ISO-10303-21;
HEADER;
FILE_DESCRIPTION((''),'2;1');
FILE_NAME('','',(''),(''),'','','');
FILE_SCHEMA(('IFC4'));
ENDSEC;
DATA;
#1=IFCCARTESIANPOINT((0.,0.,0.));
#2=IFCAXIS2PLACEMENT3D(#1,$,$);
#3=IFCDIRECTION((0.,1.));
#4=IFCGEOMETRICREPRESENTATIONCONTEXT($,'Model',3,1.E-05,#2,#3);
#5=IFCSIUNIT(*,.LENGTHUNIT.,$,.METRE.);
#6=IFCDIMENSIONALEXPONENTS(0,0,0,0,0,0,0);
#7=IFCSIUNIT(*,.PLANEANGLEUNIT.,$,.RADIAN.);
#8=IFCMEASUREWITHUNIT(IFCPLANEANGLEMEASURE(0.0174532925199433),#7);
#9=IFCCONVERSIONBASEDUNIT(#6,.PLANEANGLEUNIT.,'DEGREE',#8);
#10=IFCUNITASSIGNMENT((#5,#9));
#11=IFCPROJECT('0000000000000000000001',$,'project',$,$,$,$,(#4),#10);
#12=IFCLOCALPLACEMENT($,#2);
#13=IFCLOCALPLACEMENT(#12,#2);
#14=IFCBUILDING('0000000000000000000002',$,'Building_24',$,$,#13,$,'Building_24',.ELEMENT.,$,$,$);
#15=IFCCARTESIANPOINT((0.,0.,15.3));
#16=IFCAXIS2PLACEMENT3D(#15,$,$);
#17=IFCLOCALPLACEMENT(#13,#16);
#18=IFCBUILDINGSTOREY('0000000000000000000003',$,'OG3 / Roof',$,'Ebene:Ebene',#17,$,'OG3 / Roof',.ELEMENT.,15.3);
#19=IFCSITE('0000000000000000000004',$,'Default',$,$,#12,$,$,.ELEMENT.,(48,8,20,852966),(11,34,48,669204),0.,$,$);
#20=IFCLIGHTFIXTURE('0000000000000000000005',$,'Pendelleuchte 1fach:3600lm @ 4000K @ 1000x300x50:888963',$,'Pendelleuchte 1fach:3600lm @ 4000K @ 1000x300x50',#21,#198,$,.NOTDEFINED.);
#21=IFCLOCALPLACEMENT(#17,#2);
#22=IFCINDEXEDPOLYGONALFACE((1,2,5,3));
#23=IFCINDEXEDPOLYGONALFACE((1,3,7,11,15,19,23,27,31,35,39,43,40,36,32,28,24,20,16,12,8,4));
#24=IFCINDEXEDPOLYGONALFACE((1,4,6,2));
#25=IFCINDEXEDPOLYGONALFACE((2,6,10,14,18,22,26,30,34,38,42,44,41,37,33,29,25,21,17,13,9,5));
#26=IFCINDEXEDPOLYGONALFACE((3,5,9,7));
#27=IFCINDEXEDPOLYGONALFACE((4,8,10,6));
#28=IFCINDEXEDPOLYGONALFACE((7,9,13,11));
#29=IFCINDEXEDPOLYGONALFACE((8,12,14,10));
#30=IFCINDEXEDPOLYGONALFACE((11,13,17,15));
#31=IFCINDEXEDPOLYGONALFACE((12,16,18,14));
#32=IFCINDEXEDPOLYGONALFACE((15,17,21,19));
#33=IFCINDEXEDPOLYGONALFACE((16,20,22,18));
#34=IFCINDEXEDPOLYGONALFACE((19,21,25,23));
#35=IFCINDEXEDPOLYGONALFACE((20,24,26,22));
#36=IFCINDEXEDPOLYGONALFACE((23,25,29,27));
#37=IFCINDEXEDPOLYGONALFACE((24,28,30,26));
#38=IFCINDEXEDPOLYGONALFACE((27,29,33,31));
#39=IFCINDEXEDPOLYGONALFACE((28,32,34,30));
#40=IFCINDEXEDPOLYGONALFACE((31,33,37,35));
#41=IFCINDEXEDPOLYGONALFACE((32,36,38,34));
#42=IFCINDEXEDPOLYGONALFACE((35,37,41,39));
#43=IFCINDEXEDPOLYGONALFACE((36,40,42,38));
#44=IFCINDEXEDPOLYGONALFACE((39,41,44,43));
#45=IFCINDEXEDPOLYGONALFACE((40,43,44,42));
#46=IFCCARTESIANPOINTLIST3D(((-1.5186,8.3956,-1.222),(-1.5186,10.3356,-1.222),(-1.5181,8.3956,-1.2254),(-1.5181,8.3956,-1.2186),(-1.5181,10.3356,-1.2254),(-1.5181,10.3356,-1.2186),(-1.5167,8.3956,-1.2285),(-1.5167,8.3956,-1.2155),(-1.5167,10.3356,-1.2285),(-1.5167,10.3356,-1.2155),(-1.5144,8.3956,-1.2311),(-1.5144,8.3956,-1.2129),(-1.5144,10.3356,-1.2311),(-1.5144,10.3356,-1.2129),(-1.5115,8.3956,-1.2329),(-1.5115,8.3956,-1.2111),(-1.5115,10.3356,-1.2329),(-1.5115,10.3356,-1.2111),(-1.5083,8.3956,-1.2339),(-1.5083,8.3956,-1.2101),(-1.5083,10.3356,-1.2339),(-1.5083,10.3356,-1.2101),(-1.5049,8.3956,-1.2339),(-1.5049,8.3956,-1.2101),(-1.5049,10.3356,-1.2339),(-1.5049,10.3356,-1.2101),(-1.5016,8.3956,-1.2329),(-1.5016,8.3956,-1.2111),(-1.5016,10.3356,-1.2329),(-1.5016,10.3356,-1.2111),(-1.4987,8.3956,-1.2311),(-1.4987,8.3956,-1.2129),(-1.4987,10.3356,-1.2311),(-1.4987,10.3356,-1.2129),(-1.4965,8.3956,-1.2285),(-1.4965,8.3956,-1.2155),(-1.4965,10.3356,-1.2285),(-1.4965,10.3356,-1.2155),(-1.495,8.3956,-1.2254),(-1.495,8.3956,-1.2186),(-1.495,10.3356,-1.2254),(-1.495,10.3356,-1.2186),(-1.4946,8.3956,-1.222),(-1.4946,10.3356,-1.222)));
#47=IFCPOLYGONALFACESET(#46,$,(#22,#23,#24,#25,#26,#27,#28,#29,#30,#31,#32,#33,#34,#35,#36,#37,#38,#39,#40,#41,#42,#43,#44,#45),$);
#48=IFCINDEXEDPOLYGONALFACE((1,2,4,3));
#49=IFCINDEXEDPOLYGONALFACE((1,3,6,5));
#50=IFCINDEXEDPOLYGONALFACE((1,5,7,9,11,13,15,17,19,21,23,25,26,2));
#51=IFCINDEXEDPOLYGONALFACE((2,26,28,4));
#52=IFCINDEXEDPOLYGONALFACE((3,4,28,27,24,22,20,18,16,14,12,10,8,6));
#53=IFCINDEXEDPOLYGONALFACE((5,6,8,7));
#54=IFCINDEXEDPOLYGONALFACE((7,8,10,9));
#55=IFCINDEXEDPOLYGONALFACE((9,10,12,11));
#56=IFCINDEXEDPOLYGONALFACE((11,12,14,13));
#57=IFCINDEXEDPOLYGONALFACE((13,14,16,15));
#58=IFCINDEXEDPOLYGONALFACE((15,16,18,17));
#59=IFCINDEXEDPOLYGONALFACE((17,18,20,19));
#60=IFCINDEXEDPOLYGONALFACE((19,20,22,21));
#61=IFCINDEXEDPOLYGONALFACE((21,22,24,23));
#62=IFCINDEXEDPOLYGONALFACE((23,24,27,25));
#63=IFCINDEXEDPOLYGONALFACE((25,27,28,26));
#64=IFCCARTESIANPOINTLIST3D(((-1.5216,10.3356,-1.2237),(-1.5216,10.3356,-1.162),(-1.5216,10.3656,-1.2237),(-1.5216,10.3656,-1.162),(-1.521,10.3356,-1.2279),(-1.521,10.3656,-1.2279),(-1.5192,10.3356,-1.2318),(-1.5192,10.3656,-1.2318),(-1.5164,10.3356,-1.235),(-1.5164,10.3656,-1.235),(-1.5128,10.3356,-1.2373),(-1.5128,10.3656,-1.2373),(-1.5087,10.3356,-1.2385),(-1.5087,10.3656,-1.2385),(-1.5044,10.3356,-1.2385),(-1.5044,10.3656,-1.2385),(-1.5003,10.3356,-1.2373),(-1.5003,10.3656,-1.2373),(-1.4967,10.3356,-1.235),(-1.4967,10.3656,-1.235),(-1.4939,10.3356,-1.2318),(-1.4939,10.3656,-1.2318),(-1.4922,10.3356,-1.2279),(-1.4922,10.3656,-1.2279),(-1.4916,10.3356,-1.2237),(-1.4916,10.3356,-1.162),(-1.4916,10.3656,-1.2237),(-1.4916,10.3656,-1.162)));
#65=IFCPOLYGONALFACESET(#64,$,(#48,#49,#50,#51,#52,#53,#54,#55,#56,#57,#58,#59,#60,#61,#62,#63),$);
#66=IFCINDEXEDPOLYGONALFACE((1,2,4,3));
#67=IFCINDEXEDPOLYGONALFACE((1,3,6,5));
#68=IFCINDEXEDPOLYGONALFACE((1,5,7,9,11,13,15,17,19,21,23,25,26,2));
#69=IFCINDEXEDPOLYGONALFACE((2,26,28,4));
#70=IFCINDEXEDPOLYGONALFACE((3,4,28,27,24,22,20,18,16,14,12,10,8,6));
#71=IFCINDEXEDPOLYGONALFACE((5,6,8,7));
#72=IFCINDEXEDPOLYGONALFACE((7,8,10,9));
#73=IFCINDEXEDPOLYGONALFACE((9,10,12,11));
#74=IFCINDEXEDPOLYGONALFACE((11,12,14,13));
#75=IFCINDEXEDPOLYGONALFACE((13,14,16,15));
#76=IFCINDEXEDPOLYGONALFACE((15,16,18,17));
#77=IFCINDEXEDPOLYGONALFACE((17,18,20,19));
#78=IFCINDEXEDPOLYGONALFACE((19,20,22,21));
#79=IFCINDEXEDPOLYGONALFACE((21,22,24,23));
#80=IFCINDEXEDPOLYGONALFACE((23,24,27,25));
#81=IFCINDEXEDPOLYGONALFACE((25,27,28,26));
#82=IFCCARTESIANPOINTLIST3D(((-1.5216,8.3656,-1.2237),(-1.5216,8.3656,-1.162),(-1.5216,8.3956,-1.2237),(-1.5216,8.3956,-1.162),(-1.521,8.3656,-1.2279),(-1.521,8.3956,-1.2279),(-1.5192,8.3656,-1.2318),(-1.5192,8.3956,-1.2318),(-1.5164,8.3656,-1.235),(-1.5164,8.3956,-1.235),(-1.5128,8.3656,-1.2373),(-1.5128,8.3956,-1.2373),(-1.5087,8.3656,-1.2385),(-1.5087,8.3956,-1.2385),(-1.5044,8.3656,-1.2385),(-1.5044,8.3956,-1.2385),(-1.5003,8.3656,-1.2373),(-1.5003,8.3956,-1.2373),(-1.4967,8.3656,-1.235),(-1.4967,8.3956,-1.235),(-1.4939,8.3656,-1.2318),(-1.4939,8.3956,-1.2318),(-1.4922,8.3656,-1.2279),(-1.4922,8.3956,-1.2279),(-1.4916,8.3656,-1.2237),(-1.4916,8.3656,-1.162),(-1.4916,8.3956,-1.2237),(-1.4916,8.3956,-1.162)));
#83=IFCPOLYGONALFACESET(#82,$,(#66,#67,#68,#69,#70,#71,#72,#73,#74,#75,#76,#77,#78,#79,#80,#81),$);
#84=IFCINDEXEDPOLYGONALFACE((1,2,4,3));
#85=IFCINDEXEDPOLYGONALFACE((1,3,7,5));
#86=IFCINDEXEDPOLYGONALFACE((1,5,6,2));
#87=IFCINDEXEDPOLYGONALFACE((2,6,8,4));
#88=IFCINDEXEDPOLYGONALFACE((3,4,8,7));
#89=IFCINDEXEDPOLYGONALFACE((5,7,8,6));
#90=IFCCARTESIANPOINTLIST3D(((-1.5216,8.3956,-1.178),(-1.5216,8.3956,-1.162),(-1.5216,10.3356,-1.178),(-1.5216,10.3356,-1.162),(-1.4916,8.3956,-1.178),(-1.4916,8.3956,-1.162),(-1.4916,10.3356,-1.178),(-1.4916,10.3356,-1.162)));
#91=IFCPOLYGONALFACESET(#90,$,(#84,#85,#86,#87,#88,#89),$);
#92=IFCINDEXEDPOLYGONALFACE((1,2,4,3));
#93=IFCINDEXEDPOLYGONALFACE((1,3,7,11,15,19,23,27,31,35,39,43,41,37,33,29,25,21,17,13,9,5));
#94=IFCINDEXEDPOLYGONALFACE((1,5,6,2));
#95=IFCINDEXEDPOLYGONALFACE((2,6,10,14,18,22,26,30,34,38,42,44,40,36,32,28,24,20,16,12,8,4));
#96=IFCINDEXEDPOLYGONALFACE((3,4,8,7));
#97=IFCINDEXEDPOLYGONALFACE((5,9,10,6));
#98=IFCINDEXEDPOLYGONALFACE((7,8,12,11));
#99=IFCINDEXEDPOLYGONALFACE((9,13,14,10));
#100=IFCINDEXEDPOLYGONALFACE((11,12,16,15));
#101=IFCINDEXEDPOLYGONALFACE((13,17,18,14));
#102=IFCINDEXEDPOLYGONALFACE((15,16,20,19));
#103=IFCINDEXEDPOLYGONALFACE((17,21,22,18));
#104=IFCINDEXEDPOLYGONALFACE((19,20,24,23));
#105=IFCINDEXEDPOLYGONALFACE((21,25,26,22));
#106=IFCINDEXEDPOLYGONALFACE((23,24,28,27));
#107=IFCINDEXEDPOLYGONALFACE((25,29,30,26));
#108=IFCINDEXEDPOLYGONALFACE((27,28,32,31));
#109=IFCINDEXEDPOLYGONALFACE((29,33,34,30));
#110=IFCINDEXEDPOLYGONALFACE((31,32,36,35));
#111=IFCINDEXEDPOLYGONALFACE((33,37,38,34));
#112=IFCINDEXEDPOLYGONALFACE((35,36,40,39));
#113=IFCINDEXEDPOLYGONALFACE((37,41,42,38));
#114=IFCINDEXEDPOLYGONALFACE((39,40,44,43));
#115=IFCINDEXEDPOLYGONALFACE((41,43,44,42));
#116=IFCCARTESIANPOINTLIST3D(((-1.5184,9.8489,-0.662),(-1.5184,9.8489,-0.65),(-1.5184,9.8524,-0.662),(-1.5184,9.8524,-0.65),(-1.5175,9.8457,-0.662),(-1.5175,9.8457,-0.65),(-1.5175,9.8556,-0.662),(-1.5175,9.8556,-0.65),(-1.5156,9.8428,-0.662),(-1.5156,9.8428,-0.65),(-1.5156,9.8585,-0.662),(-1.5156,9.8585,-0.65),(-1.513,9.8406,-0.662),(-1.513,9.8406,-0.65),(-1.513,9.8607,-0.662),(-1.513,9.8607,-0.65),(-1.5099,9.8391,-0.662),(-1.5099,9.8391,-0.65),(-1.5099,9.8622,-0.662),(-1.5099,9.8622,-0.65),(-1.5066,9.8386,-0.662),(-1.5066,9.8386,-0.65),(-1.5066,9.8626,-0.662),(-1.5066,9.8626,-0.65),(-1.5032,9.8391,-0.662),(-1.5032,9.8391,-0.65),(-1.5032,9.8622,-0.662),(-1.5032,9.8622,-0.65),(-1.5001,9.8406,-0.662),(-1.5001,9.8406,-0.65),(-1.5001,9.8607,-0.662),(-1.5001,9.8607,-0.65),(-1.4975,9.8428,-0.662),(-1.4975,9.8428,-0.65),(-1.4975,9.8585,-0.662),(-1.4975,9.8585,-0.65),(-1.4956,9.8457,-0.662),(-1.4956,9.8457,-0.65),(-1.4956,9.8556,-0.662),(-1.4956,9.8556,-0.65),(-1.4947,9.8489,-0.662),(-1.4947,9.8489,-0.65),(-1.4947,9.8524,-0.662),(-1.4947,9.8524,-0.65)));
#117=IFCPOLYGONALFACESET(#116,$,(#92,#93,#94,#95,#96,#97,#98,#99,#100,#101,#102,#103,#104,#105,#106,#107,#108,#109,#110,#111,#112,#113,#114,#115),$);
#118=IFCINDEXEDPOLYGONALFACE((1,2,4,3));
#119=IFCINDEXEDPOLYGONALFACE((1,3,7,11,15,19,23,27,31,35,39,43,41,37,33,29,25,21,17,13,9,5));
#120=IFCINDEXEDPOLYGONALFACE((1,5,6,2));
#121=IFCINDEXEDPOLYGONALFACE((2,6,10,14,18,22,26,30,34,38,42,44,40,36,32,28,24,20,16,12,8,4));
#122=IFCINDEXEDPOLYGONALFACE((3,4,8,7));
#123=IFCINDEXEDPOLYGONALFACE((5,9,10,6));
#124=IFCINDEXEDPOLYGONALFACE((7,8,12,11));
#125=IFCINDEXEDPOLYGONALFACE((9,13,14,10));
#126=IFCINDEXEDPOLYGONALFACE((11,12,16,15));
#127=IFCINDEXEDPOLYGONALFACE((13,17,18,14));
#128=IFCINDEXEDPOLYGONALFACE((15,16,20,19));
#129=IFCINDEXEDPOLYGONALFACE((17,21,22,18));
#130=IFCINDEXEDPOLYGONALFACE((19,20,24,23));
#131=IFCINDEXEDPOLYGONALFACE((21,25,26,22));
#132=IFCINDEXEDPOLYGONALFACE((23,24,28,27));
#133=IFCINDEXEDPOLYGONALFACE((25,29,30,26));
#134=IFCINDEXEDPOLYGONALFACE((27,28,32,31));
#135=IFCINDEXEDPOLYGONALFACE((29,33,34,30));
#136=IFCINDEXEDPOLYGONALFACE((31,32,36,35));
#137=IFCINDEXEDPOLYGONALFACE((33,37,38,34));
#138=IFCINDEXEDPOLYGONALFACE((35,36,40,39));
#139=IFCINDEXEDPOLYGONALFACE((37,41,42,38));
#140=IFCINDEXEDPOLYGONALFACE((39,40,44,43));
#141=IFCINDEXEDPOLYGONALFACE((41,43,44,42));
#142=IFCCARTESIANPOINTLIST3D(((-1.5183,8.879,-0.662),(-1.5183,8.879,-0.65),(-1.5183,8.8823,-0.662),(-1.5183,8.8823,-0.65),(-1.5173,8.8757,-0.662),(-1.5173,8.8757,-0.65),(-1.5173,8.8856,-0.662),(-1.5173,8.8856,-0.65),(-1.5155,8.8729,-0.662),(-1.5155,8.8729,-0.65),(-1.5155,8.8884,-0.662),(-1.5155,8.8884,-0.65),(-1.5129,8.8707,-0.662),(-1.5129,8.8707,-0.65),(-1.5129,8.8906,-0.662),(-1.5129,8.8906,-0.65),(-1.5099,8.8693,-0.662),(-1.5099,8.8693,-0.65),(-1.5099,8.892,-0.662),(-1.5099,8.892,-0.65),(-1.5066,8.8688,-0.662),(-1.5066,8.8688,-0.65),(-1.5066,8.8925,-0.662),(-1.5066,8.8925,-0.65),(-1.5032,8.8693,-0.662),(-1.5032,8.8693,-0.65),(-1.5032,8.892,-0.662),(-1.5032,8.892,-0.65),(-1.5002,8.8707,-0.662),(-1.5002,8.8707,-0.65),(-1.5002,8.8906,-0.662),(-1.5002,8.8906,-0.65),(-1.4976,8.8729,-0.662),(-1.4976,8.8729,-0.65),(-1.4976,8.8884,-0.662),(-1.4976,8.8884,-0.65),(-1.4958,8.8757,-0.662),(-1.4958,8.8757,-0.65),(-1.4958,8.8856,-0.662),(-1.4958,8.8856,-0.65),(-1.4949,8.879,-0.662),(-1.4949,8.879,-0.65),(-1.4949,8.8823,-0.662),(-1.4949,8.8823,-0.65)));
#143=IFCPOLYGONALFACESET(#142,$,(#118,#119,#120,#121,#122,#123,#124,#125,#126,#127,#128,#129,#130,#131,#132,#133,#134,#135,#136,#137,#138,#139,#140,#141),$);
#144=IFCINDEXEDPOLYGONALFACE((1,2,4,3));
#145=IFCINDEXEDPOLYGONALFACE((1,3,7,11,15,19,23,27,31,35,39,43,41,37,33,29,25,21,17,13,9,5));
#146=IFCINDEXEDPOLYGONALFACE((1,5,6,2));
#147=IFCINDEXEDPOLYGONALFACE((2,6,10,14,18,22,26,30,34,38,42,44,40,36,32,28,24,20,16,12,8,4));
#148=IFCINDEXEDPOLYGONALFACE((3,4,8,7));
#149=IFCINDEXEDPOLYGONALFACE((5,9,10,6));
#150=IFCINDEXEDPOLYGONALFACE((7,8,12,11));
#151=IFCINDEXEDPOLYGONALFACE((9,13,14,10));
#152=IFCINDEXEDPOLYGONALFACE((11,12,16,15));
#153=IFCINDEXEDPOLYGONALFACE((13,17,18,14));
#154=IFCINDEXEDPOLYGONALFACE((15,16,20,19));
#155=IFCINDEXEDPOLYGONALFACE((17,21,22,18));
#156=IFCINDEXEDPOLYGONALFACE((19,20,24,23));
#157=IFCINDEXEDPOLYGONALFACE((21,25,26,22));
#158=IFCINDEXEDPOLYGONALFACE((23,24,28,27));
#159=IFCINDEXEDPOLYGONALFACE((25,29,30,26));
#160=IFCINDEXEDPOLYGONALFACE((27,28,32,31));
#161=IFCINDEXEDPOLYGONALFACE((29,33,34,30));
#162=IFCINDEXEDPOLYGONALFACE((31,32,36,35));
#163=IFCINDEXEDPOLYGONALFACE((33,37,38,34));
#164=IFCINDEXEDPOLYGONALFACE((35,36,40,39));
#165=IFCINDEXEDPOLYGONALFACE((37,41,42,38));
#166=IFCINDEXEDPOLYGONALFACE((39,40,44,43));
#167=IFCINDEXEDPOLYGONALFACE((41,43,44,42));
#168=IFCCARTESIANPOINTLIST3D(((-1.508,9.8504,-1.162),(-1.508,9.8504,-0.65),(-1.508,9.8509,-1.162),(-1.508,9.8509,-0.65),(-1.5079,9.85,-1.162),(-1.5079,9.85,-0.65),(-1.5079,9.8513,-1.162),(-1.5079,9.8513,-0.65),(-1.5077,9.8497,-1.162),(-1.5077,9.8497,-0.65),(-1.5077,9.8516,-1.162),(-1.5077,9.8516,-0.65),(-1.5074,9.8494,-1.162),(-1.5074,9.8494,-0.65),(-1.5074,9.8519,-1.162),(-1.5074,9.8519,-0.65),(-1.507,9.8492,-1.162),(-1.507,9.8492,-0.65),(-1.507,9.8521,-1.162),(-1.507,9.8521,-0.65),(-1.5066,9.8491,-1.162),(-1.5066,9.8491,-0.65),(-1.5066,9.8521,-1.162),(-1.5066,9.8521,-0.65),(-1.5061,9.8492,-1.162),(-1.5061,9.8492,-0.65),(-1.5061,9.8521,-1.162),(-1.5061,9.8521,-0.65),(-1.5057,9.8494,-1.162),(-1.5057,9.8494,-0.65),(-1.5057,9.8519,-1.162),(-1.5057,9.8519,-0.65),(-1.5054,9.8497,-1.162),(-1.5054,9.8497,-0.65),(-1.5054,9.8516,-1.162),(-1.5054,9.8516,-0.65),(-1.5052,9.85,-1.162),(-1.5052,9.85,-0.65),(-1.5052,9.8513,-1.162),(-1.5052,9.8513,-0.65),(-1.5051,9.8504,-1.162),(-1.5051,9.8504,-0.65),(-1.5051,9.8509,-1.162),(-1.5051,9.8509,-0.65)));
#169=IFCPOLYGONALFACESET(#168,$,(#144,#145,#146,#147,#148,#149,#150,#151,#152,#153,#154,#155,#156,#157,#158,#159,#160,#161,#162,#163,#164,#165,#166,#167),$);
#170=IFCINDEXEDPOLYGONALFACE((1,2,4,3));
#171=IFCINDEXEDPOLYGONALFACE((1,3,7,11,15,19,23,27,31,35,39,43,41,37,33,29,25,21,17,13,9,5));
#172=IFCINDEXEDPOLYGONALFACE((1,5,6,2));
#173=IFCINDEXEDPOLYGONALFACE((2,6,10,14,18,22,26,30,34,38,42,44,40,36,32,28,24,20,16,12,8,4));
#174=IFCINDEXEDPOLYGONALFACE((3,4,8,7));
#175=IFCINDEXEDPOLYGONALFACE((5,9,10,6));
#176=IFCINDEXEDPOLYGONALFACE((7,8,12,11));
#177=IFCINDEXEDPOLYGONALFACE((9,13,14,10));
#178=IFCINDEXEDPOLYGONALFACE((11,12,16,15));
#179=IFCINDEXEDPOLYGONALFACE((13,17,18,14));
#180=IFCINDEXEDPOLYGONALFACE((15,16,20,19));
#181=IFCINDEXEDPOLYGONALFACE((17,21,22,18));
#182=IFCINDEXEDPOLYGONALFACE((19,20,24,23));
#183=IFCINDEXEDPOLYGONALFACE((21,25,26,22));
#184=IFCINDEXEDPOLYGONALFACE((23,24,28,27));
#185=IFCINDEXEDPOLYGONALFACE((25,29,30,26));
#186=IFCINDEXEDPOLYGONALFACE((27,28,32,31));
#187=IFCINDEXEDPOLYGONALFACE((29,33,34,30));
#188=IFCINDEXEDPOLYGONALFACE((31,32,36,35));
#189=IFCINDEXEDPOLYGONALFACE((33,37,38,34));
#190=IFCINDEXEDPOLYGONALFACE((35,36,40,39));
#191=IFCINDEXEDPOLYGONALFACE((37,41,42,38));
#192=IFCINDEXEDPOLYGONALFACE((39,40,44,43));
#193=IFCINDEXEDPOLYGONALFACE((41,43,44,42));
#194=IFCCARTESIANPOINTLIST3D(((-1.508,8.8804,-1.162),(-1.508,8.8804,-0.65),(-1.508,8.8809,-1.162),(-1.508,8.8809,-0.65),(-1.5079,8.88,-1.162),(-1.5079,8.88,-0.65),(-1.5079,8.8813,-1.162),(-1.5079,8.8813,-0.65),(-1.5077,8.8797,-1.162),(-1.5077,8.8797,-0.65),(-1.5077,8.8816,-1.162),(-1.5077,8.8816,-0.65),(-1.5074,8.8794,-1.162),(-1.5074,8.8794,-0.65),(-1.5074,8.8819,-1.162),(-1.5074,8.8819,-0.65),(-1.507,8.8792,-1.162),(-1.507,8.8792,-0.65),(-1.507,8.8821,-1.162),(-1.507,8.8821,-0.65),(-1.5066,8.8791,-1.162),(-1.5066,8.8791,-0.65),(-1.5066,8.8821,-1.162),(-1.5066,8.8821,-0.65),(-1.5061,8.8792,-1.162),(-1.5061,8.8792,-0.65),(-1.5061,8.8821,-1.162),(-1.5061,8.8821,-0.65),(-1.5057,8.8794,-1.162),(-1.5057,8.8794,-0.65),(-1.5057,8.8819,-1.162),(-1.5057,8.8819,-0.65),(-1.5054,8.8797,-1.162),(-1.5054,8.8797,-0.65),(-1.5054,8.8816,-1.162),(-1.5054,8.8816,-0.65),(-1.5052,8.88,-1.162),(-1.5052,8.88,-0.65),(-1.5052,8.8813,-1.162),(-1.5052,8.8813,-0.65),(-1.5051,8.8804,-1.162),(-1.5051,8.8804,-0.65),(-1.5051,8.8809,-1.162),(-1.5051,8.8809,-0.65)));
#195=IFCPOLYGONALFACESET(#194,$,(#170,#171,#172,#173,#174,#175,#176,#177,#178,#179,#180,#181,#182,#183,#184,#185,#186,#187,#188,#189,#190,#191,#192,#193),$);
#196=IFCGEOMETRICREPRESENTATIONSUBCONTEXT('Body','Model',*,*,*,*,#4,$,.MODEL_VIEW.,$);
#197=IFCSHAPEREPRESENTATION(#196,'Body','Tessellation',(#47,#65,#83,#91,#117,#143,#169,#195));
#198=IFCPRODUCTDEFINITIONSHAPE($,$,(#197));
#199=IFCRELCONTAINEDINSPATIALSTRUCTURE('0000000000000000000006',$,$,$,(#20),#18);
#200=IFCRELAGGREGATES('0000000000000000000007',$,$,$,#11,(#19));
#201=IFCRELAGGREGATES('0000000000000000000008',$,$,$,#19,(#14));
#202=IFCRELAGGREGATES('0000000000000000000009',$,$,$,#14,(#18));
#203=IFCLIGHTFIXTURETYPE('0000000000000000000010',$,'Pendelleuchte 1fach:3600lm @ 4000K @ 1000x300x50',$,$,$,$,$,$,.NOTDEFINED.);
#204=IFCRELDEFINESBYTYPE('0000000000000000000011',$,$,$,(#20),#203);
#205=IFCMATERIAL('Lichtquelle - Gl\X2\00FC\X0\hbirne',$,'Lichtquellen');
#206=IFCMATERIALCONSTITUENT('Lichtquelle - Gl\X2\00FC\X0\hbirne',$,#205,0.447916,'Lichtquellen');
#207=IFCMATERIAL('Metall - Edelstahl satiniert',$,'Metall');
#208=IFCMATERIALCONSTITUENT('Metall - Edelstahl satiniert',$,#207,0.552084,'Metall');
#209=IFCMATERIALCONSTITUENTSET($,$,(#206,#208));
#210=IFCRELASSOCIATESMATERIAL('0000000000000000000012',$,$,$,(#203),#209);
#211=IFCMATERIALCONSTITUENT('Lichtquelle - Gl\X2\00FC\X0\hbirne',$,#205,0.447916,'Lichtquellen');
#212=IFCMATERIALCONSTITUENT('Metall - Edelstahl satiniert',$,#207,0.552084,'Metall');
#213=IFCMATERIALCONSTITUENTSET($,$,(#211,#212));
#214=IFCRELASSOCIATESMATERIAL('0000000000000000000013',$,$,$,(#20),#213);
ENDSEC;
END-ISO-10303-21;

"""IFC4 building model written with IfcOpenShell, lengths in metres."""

from ifc_helpers import new_model, entity, si_unit, converted_unit, direction, frame, origin, place, context, subcontext, project, spatial, line, arc, indexed_curve, outline, extrude, source, transform, mapped, material, constituent, constituent_set, type_object, type_shapes, element, save


model = new_model("IFC4")

# Units and contexts
model_context = context("Model", 3, precision=1e-05, world=origin(), true_north=direction((0.0, 1.0)))
body_context = subcontext(model_context, "Body", "Model", "MODEL_VIEW")
ifc_project = project(units=[si_unit("LENGTHUNIT", "METRE"), converted_unit("PLANEANGLEUNIT", "DEGREE", entity("IfcPlaneAngleMeasure", 0.0174532925199433), si_unit("PLANEANGLEUNIT", "RADIAN"), dimensions=[0, 0, 0, 0, 0, 0, 0])], contexts=[model_context])

# Site, building, storey
site_placement = place(None, origin())
site = spatial("IfcSite", under=ifc_project, at=site_placement, Name="Default", CompositionType="ELEMENT", RefLatitude=(48, 8, 20, 852966), RefLongitude=(11, 34, 48, 669204), RefElevation=0.0)
building_placement = place(site_placement, origin())
building = spatial("IfcBuilding", under=site, at=building_placement, Name="Building_24", LongName="Building_24", CompositionType="ELEMENT")
storey_placement = place(building_placement, frame((0.0, 0.0, 15.3)))
storey = spatial("IfcBuildingStorey", under=building, at=storey_placement, Name="OG3 / Roof", ObjectType="Ebene:Ebene", LongName="OG3 / Roof", CompositionType="ELEMENT", Elevation=15.3)

# Light fixture
ifc_material_1 = material(Name="Lichtquelle - Glühbirne", Category="Lichtquellen")
ifc_material_2 = material(Name="Metall - Edelstahl satiniert", Category="Metall")
ifc_constituent_1 = constituent(ifc_material_1, Name="Lichtquelle - Glühbirne", Category="Lichtquellen", fraction=0.447916)
ifc_constituent_2 = constituent(ifc_material_2, Name="Metall - Edelstahl satiniert", Category="Metall", fraction=0.552084)
ifc_constituent_set_1 = constituent_set(constituents=[ifc_constituent_1, ifc_constituent_2])
light_fixture_type_1 = type_object("IfcLightFixtureType", Name="Pendelleuchte 1fach:3600lm @ 4000K @ 1000x300x50", PredefinedType="NOTDEFINED", material=ifc_constituent_set_1)
shared_shape_1 = source(origin(), body_context, "Body", "SweptSolid", [
    extrude(outline(indexed_curve([(-0.012, 0.0), (0.0, -0.012), (0.012, 0.0), (0.0, 0.012)], segments=[arc(1, 2, 3), arc(3, 4, 1)], self_intersect=False)), frame((-0.97, 0.0, -0.572), z_axis=(1.0, 0.0, 0.0), x_axis=(0.0, 1.0, 0.0)), (0.0, 0.0, 1.0), 1.94),
    extrude(outline(indexed_curve([(-0.0308, -0.015), (0.0308, -0.015), (0.0308, 0.015), (-0.0308, 0.015), (-0.0458, 0.0)], segments=[line(1, 2, 3, 4), arc(4, 5, 1)], self_intersect=False)), frame((0.97, 0.0, -0.5428), z_axis=(1.0, 0.0, 0.0), x_axis=(0.0, 0.0, 1.0)), (0.0, 0.0, 1.0), 0.03),
    extrude(outline(indexed_curve([(-0.0308, -0.015), (0.0308, -0.015), (0.0308, 0.015), (-0.0308, 0.015), (-0.0458, 0.0)], segments=[line(1, 2, 3, 4), arc(4, 5, 1)], self_intersect=False)), frame((-1.0, 0.0, -0.5428), z_axis=(1.0, 0.0, 0.0), x_axis=(0.0, 0.0, 1.0)), (0.0, 0.0, 1.0), 0.03),
    extrude(outline(indexed_curve([(-0.97, -0.015), (0.97, -0.015), (0.97, 0.015), (-0.97, 0.015), (-0.97, -0.015)], self_intersect=False)), frame((0.0, 0.0, -0.528), z_axis=(0.0, 0.0, 1.0), x_axis=(-1.0, 0.0, 0.0)), (0.0, 0.0, 1.0), 0.016),
    extrude(outline(indexed_curve([(-0.012, 0.0), (0.0, -0.012), (0.012, 0.0), (0.0, 0.012)], segments=[arc(1, 2, 3), arc(3, 4, 1)], self_intersect=False)), frame((0.485, 0.0, -0.012)), (0.0, 0.0, 1.0), 0.012),
    extrude(outline(indexed_curve([(-0.0118, 0.0), (0.0, -0.0118), (0.0118, 0.0), (0.0, 0.0118)], segments=[arc(1, 2, 3), arc(3, 4, 1)], self_intersect=False)), frame((-0.485, 0.0, -0.012)), (0.0, 0.0, 1.0), 0.012),
    extrude(outline(indexed_curve([(-0.0015, 0.0), (0.0, -0.0015), (0.0015, 0.0), (0.0, 0.0015)], segments=[arc(1, 2, 3), arc(3, 4, 1)], self_intersect=False)), frame((0.485, 0.0, -0.512)), (0.0, 0.0, 1.0), 0.512),
    extrude(outline(indexed_curve([(-0.0015, 0.0), (0.0, -0.0015), (0.0015, 0.0), (0.0, 0.0015)], segments=[arc(1, 2, 3), arc(3, 4, 1)], self_intersect=False)), frame((-0.485, 0.0, -0.512)), (0.0, 0.0, 1.0), 0.512),
])
type_shapes(light_fixture_type_1, [shared_shape_1])
ifc_constituent_3 = constituent(ifc_material_1, Name="Lichtquelle - Glühbirne", Category="Lichtquellen", fraction=0.447916)
ifc_constituent_4 = constituent(ifc_material_2, Name="Metall - Edelstahl satiniert", Category="Metall", fraction=0.552084)
ifc_constituent_set_2 = constituent_set(constituents=[ifc_constituent_3, ifc_constituent_4])
light_fixture_1_placement = place(storey_placement, frame((-1.5066, 9.3656, -0.65), z_axis=(0.0, 0.0, 1.0), x_axis=(0.0, 1.0, 0.0)))
element("IfcLightFixture", 1, at=light_fixture_1_placement, inside=storey, type_object=light_fixture_type_1, material=ifc_constituent_set_2, Name="Pendelleuchte 1fach:3600lm @ 4000K @ 1000x300x50:888963", ObjectType="Pendelleuchte 1fach:3600lm @ 4000K @ 1000x300x50", PredefinedType="NOTDEFINED", context=body_context, shape_type="MappedRepresentation", body=[
    mapped(shared_shape_1, transform((0.0, 0.0, 0.0), scale=1.0)),
])

save(model, "model.ifc")
